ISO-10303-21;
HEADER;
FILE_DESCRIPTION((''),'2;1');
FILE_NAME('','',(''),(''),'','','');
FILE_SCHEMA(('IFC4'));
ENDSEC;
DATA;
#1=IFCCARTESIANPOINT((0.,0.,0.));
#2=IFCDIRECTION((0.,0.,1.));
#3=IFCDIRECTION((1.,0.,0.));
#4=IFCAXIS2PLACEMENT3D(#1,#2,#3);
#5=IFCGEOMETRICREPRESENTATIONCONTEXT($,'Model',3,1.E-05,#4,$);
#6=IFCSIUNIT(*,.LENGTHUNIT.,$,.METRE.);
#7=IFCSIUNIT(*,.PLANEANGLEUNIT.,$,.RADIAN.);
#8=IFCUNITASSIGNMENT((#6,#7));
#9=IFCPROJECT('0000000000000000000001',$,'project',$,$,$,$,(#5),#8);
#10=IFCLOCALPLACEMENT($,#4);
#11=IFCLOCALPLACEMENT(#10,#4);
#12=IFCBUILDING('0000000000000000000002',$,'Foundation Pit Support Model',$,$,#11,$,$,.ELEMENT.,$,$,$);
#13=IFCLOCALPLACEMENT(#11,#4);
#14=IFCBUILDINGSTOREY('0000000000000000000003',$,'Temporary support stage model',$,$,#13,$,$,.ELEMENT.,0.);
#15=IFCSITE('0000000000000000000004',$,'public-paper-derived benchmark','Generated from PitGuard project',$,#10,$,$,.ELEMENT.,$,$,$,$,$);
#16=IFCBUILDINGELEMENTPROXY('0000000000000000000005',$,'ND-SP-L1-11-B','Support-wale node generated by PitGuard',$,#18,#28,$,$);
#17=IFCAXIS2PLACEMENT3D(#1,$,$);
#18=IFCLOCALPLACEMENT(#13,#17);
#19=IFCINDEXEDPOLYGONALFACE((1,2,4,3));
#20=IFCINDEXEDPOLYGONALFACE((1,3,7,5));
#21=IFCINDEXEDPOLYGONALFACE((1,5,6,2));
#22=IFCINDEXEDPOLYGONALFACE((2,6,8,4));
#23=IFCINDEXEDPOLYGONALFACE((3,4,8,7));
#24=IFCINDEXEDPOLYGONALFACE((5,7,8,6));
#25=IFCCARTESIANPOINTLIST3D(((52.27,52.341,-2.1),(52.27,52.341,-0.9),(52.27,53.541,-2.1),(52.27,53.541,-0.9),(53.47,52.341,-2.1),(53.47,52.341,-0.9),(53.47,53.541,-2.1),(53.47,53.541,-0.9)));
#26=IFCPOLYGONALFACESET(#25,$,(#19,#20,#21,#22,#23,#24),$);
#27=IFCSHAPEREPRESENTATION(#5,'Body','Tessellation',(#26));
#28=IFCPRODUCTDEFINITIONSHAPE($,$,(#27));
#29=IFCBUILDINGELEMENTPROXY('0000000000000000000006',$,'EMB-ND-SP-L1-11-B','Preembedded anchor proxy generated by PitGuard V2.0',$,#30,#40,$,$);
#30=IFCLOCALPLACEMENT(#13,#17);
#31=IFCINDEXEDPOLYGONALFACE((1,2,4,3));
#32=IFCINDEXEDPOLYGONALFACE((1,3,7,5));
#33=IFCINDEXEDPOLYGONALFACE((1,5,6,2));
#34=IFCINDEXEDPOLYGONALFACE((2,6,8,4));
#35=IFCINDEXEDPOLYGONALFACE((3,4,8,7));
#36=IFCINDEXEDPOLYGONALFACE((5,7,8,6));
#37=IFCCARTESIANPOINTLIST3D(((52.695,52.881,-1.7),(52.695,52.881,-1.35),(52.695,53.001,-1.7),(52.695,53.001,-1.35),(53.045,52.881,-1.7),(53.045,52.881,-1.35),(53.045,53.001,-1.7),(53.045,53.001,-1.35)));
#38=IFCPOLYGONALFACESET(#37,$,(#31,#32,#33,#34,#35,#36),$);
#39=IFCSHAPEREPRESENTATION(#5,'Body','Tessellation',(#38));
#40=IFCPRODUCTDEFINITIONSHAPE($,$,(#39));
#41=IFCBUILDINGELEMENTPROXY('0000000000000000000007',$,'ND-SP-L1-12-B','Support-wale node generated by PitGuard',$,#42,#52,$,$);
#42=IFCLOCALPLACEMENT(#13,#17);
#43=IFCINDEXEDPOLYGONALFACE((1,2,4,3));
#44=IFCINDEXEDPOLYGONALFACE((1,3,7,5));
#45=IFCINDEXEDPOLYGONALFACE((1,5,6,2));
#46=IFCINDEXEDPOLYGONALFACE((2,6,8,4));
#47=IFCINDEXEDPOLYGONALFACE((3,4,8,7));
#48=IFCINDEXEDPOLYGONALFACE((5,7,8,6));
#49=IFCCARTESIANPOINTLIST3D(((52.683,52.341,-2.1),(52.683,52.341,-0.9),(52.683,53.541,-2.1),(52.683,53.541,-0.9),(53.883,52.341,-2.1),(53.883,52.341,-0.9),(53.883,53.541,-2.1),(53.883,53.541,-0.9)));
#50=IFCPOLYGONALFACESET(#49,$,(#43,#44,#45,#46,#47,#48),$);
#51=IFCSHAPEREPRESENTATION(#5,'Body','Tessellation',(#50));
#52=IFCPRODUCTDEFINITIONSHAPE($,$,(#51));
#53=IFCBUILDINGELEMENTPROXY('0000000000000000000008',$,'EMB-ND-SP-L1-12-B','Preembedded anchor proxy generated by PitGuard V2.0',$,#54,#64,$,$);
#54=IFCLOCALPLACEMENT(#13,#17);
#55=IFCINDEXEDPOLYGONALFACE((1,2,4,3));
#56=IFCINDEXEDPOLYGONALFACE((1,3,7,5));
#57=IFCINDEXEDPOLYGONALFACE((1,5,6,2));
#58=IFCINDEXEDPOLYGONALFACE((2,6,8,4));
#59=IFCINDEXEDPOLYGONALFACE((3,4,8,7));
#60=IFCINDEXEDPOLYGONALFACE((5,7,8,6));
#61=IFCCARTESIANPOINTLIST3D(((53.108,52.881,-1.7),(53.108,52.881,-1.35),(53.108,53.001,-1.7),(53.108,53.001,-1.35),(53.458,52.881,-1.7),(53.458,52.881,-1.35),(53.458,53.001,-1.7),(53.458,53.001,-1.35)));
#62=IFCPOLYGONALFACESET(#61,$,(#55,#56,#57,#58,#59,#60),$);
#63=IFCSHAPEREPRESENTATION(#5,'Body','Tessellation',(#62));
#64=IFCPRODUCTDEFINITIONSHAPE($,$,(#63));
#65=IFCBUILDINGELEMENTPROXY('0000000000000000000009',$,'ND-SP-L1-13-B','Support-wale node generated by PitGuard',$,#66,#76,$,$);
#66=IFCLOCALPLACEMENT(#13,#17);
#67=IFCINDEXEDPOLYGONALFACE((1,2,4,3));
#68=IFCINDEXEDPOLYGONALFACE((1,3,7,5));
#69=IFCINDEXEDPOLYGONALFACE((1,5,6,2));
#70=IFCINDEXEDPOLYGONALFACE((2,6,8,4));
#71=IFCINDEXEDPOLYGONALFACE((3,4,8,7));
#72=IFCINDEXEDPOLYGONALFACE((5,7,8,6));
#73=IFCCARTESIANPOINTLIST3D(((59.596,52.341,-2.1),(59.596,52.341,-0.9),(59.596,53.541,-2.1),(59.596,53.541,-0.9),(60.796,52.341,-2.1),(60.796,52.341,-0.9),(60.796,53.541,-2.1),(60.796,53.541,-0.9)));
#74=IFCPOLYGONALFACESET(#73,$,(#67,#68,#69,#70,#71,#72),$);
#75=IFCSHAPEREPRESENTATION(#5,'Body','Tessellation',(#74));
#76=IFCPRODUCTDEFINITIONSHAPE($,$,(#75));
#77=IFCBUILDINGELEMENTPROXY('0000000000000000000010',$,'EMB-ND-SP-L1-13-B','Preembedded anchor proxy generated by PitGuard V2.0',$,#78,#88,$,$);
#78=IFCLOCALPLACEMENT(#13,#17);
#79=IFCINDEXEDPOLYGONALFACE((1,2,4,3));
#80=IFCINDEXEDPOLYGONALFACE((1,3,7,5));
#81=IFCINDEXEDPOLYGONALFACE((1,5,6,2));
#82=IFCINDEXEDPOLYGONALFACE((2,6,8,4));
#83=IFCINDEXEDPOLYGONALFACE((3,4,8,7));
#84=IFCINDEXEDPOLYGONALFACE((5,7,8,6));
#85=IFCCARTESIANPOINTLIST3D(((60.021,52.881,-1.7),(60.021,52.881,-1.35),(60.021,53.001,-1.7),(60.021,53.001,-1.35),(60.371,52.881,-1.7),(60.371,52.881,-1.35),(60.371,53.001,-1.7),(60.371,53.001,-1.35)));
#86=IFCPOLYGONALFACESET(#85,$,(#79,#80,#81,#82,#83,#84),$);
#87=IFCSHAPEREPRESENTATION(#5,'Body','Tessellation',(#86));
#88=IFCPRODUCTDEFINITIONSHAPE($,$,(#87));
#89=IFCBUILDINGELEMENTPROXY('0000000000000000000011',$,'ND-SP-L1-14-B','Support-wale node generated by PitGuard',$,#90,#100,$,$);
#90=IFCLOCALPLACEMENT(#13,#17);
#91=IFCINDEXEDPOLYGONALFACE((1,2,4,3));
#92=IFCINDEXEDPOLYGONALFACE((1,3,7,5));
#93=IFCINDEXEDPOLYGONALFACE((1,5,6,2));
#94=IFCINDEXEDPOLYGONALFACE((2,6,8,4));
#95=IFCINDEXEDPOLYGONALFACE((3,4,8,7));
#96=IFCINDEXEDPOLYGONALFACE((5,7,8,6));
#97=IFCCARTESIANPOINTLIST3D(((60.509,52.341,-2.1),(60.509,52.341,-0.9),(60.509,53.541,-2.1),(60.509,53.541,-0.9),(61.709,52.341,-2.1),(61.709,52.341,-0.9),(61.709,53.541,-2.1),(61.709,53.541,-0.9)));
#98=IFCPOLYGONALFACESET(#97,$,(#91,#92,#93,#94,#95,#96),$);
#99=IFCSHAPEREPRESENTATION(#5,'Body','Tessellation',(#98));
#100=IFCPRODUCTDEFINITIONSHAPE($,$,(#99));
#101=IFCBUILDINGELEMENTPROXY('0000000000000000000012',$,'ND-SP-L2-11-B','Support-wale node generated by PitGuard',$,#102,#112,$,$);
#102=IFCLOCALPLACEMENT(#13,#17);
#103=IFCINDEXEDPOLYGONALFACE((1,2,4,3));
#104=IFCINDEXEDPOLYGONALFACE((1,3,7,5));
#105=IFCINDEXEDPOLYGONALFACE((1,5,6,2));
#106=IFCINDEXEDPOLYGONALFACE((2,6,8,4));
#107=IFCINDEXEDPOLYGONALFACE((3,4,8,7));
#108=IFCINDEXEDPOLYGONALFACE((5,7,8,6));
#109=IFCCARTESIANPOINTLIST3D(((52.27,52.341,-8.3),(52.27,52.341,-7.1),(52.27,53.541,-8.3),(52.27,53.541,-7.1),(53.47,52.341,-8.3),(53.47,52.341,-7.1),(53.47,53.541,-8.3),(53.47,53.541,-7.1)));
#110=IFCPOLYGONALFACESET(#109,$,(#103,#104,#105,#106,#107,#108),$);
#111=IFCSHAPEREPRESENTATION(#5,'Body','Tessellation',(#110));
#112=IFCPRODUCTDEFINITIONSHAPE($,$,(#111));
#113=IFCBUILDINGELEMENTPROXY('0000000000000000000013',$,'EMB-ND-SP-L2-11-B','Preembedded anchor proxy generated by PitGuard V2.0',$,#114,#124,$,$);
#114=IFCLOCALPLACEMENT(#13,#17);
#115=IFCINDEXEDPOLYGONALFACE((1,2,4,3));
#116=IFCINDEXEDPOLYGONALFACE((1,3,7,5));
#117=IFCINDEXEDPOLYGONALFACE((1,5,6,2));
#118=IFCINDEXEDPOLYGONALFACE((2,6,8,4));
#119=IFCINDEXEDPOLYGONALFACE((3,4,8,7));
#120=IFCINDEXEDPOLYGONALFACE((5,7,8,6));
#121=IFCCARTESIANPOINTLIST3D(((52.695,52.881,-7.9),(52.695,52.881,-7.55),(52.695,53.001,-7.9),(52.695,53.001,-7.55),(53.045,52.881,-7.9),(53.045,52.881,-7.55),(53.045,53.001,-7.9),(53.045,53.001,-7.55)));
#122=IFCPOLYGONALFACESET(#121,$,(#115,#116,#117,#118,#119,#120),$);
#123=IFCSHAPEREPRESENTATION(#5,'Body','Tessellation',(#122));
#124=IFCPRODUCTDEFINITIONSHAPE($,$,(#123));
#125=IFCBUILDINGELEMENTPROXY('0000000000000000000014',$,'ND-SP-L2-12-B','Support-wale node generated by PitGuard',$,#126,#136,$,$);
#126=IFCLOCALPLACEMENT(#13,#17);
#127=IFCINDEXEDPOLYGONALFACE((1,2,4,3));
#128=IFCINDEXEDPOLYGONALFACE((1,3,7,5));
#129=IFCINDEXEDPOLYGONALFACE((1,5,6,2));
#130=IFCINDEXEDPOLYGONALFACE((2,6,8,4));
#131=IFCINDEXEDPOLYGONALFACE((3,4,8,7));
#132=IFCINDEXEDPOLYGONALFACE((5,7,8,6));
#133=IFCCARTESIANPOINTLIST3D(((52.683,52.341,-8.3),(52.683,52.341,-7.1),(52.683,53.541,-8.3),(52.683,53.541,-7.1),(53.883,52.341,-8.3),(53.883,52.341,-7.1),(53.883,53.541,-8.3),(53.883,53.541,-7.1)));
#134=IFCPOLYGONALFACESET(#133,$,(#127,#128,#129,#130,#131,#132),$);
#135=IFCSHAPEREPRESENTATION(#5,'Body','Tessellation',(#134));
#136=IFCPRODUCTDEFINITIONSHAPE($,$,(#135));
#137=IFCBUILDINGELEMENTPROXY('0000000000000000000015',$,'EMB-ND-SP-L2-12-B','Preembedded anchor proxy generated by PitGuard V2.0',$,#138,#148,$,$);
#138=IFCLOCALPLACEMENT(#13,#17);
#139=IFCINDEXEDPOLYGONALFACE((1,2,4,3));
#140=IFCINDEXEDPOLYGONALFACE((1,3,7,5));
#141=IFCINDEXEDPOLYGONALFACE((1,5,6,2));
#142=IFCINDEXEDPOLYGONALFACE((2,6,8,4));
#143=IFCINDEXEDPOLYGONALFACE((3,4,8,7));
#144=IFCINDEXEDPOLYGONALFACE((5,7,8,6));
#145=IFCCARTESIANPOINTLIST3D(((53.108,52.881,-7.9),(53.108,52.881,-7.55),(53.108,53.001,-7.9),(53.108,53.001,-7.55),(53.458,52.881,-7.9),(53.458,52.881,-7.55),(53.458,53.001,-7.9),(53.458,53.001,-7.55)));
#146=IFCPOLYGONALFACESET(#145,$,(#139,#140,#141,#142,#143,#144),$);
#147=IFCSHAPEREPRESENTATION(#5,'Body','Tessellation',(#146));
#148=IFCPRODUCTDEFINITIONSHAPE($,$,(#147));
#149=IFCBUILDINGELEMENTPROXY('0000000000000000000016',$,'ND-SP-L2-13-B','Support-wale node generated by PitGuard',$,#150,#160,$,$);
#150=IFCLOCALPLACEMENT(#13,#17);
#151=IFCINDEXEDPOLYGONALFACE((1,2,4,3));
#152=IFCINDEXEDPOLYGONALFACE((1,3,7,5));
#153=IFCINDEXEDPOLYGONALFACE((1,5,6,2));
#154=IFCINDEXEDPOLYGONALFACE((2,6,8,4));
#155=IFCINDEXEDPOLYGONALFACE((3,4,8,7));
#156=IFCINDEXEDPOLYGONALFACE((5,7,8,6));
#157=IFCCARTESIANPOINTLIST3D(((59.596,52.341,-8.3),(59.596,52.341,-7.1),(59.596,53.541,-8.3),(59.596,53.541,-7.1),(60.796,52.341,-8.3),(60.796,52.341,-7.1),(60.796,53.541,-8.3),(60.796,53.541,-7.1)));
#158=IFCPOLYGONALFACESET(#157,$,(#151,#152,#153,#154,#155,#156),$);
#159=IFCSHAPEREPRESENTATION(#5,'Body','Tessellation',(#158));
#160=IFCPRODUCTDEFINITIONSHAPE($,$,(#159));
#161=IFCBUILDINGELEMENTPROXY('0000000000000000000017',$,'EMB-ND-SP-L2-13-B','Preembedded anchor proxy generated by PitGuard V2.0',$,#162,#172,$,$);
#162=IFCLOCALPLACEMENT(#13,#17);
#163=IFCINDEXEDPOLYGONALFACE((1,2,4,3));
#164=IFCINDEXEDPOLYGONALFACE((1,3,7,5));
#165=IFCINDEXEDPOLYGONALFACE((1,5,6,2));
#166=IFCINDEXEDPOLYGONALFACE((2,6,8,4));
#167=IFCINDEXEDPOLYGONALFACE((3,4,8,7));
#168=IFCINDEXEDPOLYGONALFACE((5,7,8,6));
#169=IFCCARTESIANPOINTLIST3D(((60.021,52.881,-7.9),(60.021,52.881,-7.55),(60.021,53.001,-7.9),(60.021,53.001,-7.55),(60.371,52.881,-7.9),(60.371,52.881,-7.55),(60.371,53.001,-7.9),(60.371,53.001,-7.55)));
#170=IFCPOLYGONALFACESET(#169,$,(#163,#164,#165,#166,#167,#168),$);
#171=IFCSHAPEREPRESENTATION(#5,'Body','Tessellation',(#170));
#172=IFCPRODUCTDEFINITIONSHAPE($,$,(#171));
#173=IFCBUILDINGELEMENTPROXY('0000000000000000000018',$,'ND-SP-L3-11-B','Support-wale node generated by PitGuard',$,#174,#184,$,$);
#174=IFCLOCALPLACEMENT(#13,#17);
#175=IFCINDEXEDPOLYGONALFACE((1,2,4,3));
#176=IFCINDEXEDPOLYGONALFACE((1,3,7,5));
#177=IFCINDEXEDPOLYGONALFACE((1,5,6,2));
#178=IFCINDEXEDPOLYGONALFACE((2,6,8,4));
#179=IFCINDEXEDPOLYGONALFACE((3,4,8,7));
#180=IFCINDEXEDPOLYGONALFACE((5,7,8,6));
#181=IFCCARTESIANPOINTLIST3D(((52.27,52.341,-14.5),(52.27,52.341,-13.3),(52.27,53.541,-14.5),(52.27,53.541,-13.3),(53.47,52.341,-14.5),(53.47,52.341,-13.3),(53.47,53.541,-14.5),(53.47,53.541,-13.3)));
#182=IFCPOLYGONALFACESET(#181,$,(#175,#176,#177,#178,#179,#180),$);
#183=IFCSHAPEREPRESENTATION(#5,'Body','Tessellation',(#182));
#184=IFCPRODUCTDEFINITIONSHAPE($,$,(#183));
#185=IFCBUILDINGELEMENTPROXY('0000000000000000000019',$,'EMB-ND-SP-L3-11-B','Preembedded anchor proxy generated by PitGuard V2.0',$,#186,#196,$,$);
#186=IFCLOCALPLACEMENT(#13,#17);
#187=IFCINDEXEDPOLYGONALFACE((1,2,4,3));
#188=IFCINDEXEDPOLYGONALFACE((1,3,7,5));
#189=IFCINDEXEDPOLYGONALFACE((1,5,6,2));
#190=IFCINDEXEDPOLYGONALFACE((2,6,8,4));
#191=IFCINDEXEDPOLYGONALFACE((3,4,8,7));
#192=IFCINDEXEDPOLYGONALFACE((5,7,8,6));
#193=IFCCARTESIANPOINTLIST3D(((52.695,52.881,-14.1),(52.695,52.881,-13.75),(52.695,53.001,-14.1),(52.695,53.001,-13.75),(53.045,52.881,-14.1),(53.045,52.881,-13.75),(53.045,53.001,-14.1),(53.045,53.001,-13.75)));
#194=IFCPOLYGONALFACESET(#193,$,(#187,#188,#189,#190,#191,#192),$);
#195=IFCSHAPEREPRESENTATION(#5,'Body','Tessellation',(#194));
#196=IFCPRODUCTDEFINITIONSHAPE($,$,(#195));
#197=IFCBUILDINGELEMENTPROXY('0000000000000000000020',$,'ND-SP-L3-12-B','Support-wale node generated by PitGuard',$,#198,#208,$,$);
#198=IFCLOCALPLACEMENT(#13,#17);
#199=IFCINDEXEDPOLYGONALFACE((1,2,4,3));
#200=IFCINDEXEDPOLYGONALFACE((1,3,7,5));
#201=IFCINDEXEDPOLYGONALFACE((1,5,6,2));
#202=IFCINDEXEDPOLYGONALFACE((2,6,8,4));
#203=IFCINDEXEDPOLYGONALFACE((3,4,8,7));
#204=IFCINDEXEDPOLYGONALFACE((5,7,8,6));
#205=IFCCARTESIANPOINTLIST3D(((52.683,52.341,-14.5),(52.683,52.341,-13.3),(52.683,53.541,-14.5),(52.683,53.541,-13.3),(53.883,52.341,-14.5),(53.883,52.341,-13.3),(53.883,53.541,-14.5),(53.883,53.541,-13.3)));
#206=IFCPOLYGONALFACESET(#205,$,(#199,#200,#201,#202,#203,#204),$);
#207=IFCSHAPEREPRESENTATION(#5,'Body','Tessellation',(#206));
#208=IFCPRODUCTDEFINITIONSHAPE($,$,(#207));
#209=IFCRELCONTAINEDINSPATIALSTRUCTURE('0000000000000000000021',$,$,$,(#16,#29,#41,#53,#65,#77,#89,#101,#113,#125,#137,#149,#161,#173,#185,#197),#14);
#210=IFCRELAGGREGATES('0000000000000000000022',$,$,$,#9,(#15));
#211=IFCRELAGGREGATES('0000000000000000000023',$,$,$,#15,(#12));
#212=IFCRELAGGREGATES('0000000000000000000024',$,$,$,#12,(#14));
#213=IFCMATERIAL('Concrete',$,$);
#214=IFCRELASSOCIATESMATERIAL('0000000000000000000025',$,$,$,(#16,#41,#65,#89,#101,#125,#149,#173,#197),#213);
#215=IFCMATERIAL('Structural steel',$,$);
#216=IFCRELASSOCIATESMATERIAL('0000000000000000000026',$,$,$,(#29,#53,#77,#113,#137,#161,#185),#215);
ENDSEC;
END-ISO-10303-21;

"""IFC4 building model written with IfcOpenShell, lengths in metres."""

from ifc_helpers import new_model, si_unit, frame, origin_with_axes, origin_2d, place, context, project, spatial, rectangle, extrude, material, element, save


model = new_model("IFC4")

# Units and contexts
model_context = context("Model", 3, precision=1e-05, world=origin_with_axes())
ifc_project = project(units=[si_unit("LENGTHUNIT", "METRE"), si_unit("PLANEANGLEUNIT", "RADIAN")], contexts=[model_context])

# Site, building, storey
site_placement = place(None, origin_with_axes())
site = spatial("IfcSite", under=ifc_project, at=site_placement, Name="public-paper-derived benchmark", Description="Generated from PitGuard project", CompositionType="ELEMENT")
building_placement = place(site_placement, origin_with_axes())
building = spatial("IfcBuilding", under=site, at=building_placement, Name="Foundation Pit Support Model", CompositionType="ELEMENT")
storey_placement = place(building_placement, origin_with_axes())
storey = spatial("IfcBuildingStorey", under=building, at=storey_placement, Name="Temporary support stage model", CompositionType="ELEMENT", Elevation=0.0)

# Shared definitions
ifc_material_1 = material(Name="Structural steel")

# Shared definitions
ifc_material_2 = material(Name="Concrete")

# Building element proxies
proxy_1_placement = place(storey_placement, frame((52.87, 52.941, -2.1), z_axis=(0.0, 0.0, 1.0), x_axis=(1.0, 0.0, 0.0)))
element("IfcBuildingElementProxy", 1, at=proxy_1_placement, inside=storey, material=ifc_material_2, Name="ND-SP-L1-11-B", Description="Support-wale node generated by PitGuard", context=model_context, shape_type="SweptSolid", body=[
    extrude(rectangle(XDim=1.2, YDim=1.2, at=origin_2d()), origin_with_axes(), (0.0, 0.0, 1.0), 1.2),
])
proxy_2_placement = place(storey_placement, frame((52.87, 52.941, -1.7), z_axis=(0.0, 0.0, 1.0), x_axis=(1.0, 0.0, 0.0)))
element("IfcBuildingElementProxy", 2, at=proxy_2_placement, inside=storey, material=ifc_material_1, Name="EMB-ND-SP-L1-11-B", Description="Preembedded anchor proxy generated by PitGuard V2.0", context=model_context, shape_type="SweptSolid", body=[
    extrude(rectangle(XDim=0.35, YDim=0.12, at=origin_2d()), origin_with_axes(), (0.0, 0.0, 1.0), 0.35),
])
proxy_3_placement = place(storey_placement, frame((53.283, 52.941, -2.1), z_axis=(0.0, 0.0, 1.0), x_axis=(1.0, 0.0, 0.0)))
element("IfcBuildingElementProxy", 3, at=proxy_3_placement, inside=storey, material=ifc_material_2, Name="ND-SP-L1-12-B", Description="Support-wale node generated by PitGuard", context=model_context, shape_type="SweptSolid", body=[
    extrude(rectangle(XDim=1.2, YDim=1.2, at=origin_2d()), origin_with_axes(), (0.0, 0.0, 1.0), 1.2),
])
proxy_4_placement = place(storey_placement, frame((53.283, 52.941, -1.7), z_axis=(0.0, 0.0, 1.0), x_axis=(1.0, 0.0, 0.0)))
element("IfcBuildingElementProxy", 4, at=proxy_4_placement, inside=storey, material=ifc_material_1, Name="EMB-ND-SP-L1-12-B", Description="Preembedded anchor proxy generated by PitGuard V2.0", context=model_context, shape_type="SweptSolid", body=[
    extrude(rectangle(XDim=0.35, YDim=0.12, at=origin_2d()), origin_with_axes(), (0.0, 0.0, 1.0), 0.35),
])
proxy_5_placement = place(storey_placement, frame((60.196, 52.941, -2.1), z_axis=(0.0, 0.0, 1.0), x_axis=(1.0, 0.0, 0.0)))
element("IfcBuildingElementProxy", 5, at=proxy_5_placement, inside=storey, material=ifc_material_2, Name="ND-SP-L1-13-B", Description="Support-wale node generated by PitGuard", context=model_context, shape_type="SweptSolid", body=[
    extrude(rectangle(XDim=1.2, YDim=1.2, at=origin_2d()), origin_with_axes(), (0.0, 0.0, 1.0), 1.2),
])
proxy_6_placement = place(storey_placement, frame((60.196, 52.941, -1.7), z_axis=(0.0, 0.0, 1.0), x_axis=(1.0, 0.0, 0.0)))
element("IfcBuildingElementProxy", 6, at=proxy_6_placement, inside=storey, material=ifc_material_1, Name="EMB-ND-SP-L1-13-B", Description="Preembedded anchor proxy generated by PitGuard V2.0", context=model_context, shape_type="SweptSolid", body=[
    extrude(rectangle(XDim=0.35, YDim=0.12, at=origin_2d()), origin_with_axes(), (0.0, 0.0, 1.0), 0.35),
])
for number, where, z_axis, x_axis, name in (
    (7, (61.109, 52.941, -2.1), (0.0, 0.0, 1.0), (1.0, 0.0, 0.0), "ND-SP-L1-14-B"),
    (8, (52.87, 52.941, -8.3), (0.0, 0.0, 1.0), (1.0, 0.0, 0.0), "ND-SP-L2-11-B"),
):
    element("IfcBuildingElementProxy", number, at=place(storey_placement, frame(where, z_axis=z_axis, x_axis=x_axis)), inside=storey, material=ifc_material_2, Name=name, Description="Support-wale node generated by PitGuard", context=model_context, shape_type="SweptSolid", body=[
        extrude(rectangle(XDim=1.2, YDim=1.2, at=origin_2d()), origin_with_axes(), (0.0, 0.0, 1.0), 1.2),
    ])
proxy_7_placement = place(storey_placement, frame((52.87, 52.941, -7.9), z_axis=(0.0, 0.0, 1.0), x_axis=(1.0, 0.0, 0.0)))
element("IfcBuildingElementProxy", 9, at=proxy_7_placement, inside=storey, material=ifc_material_1, Name="EMB-ND-SP-L2-11-B", Description="Preembedded anchor proxy generated by PitGuard V2.0", context=model_context, shape_type="SweptSolid", body=[
    extrude(rectangle(XDim=0.35, YDim=0.12, at=origin_2d()), origin_with_axes(), (0.0, 0.0, 1.0), 0.35),
])
proxy_8_placement = place(storey_placement, frame((53.283, 52.941, -8.3), z_axis=(0.0, 0.0, 1.0), x_axis=(1.0, 0.0, 0.0)))
element("IfcBuildingElementProxy", 10, at=proxy_8_placement, inside=storey, material=ifc_material_2, Name="ND-SP-L2-12-B", Description="Support-wale node generated by PitGuard", context=model_context, shape_type="SweptSolid", body=[
    extrude(rectangle(XDim=1.2, YDim=1.2, at=origin_2d()), origin_with_axes(), (0.0, 0.0, 1.0), 1.2),
])
proxy_9_placement = place(storey_placement, frame((53.283, 52.941, -7.9), z_axis=(0.0, 0.0, 1.0), x_axis=(1.0, 0.0, 0.0)))
element("IfcBuildingElementProxy", 11, at=proxy_9_placement, inside=storey, material=ifc_material_1, Name="EMB-ND-SP-L2-12-B", Description="Preembedded anchor proxy generated by PitGuard V2.0", context=model_context, shape_type="SweptSolid", body=[
    extrude(rectangle(XDim=0.35, YDim=0.12, at=origin_2d()), origin_with_axes(), (0.0, 0.0, 1.0), 0.35),
])
proxy_10_placement = place(storey_placement, frame((60.196, 52.941, -8.3), z_axis=(0.0, 0.0, 1.0), x_axis=(1.0, 0.0, 0.0)))
element("IfcBuildingElementProxy", 12, at=proxy_10_placement, inside=storey, material=ifc_material_2, Name="ND-SP-L2-13-B", Description="Support-wale node generated by PitGuard", context=model_context, shape_type="SweptSolid", body=[
    extrude(rectangle(XDim=1.2, YDim=1.2, at=origin_2d()), origin_with_axes(), (0.0, 0.0, 1.0), 1.2),
])
proxy_11_placement = place(storey_placement, frame((60.196, 52.941, -7.9), z_axis=(0.0, 0.0, 1.0), x_axis=(1.0, 0.0, 0.0)))
element("IfcBuildingElementProxy", 13, at=proxy_11_placement, inside=storey, material=ifc_material_1, Name="EMB-ND-SP-L2-13-B", Description="Preembedded anchor proxy generated by PitGuard V2.0", context=model_context, shape_type="SweptSolid", body=[
    extrude(rectangle(XDim=0.35, YDim=0.12, at=origin_2d()), origin_with_axes(), (0.0, 0.0, 1.0), 0.35),
])
proxy_12_placement = place(storey_placement, frame((52.87, 52.941, -14.5), z_axis=(0.0, 0.0, 1.0), x_axis=(1.0, 0.0, 0.0)))
element("IfcBuildingElementProxy", 14, at=proxy_12_placement, inside=storey, material=ifc_material_2, Name="ND-SP-L3-11-B", Description="Support-wale node generated by PitGuard", context=model_context, shape_type="SweptSolid", body=[
    extrude(rectangle(XDim=1.2, YDim=1.2, at=origin_2d()), origin_with_axes(), (0.0, 0.0, 1.0), 1.2),
])
proxy_13_placement = place(storey_placement, frame((52.87, 52.941, -14.1), z_axis=(0.0, 0.0, 1.0), x_axis=(1.0, 0.0, 0.0)))
element("IfcBuildingElementProxy", 15, at=proxy_13_placement, inside=storey, material=ifc_material_1, Name="EMB-ND-SP-L3-11-B", Description="Preembedded anchor proxy generated by PitGuard V2.0", context=model_context, shape_type="SweptSolid", body=[
    extrude(rectangle(XDim=0.35, YDim=0.12, at=origin_2d()), origin_with_axes(), (0.0, 0.0, 1.0), 0.35),
])
proxy_14_placement = place(storey_placement, frame((53.283, 52.941, -14.5), z_axis=(0.0, 0.0, 1.0), x_axis=(1.0, 0.0, 0.0)))
element("IfcBuildingElementProxy", 16, at=proxy_14_placement, inside=storey, material=ifc_material_2, Name="ND-SP-L3-12-B", Description="Support-wale node generated by PitGuard", context=model_context, shape_type="SweptSolid", body=[
    extrude(rectangle(XDim=1.2, YDim=1.2, at=origin_2d()), origin_with_axes(), (0.0, 0.0, 1.0), 1.2),
])

save(model, "model.ifc")
